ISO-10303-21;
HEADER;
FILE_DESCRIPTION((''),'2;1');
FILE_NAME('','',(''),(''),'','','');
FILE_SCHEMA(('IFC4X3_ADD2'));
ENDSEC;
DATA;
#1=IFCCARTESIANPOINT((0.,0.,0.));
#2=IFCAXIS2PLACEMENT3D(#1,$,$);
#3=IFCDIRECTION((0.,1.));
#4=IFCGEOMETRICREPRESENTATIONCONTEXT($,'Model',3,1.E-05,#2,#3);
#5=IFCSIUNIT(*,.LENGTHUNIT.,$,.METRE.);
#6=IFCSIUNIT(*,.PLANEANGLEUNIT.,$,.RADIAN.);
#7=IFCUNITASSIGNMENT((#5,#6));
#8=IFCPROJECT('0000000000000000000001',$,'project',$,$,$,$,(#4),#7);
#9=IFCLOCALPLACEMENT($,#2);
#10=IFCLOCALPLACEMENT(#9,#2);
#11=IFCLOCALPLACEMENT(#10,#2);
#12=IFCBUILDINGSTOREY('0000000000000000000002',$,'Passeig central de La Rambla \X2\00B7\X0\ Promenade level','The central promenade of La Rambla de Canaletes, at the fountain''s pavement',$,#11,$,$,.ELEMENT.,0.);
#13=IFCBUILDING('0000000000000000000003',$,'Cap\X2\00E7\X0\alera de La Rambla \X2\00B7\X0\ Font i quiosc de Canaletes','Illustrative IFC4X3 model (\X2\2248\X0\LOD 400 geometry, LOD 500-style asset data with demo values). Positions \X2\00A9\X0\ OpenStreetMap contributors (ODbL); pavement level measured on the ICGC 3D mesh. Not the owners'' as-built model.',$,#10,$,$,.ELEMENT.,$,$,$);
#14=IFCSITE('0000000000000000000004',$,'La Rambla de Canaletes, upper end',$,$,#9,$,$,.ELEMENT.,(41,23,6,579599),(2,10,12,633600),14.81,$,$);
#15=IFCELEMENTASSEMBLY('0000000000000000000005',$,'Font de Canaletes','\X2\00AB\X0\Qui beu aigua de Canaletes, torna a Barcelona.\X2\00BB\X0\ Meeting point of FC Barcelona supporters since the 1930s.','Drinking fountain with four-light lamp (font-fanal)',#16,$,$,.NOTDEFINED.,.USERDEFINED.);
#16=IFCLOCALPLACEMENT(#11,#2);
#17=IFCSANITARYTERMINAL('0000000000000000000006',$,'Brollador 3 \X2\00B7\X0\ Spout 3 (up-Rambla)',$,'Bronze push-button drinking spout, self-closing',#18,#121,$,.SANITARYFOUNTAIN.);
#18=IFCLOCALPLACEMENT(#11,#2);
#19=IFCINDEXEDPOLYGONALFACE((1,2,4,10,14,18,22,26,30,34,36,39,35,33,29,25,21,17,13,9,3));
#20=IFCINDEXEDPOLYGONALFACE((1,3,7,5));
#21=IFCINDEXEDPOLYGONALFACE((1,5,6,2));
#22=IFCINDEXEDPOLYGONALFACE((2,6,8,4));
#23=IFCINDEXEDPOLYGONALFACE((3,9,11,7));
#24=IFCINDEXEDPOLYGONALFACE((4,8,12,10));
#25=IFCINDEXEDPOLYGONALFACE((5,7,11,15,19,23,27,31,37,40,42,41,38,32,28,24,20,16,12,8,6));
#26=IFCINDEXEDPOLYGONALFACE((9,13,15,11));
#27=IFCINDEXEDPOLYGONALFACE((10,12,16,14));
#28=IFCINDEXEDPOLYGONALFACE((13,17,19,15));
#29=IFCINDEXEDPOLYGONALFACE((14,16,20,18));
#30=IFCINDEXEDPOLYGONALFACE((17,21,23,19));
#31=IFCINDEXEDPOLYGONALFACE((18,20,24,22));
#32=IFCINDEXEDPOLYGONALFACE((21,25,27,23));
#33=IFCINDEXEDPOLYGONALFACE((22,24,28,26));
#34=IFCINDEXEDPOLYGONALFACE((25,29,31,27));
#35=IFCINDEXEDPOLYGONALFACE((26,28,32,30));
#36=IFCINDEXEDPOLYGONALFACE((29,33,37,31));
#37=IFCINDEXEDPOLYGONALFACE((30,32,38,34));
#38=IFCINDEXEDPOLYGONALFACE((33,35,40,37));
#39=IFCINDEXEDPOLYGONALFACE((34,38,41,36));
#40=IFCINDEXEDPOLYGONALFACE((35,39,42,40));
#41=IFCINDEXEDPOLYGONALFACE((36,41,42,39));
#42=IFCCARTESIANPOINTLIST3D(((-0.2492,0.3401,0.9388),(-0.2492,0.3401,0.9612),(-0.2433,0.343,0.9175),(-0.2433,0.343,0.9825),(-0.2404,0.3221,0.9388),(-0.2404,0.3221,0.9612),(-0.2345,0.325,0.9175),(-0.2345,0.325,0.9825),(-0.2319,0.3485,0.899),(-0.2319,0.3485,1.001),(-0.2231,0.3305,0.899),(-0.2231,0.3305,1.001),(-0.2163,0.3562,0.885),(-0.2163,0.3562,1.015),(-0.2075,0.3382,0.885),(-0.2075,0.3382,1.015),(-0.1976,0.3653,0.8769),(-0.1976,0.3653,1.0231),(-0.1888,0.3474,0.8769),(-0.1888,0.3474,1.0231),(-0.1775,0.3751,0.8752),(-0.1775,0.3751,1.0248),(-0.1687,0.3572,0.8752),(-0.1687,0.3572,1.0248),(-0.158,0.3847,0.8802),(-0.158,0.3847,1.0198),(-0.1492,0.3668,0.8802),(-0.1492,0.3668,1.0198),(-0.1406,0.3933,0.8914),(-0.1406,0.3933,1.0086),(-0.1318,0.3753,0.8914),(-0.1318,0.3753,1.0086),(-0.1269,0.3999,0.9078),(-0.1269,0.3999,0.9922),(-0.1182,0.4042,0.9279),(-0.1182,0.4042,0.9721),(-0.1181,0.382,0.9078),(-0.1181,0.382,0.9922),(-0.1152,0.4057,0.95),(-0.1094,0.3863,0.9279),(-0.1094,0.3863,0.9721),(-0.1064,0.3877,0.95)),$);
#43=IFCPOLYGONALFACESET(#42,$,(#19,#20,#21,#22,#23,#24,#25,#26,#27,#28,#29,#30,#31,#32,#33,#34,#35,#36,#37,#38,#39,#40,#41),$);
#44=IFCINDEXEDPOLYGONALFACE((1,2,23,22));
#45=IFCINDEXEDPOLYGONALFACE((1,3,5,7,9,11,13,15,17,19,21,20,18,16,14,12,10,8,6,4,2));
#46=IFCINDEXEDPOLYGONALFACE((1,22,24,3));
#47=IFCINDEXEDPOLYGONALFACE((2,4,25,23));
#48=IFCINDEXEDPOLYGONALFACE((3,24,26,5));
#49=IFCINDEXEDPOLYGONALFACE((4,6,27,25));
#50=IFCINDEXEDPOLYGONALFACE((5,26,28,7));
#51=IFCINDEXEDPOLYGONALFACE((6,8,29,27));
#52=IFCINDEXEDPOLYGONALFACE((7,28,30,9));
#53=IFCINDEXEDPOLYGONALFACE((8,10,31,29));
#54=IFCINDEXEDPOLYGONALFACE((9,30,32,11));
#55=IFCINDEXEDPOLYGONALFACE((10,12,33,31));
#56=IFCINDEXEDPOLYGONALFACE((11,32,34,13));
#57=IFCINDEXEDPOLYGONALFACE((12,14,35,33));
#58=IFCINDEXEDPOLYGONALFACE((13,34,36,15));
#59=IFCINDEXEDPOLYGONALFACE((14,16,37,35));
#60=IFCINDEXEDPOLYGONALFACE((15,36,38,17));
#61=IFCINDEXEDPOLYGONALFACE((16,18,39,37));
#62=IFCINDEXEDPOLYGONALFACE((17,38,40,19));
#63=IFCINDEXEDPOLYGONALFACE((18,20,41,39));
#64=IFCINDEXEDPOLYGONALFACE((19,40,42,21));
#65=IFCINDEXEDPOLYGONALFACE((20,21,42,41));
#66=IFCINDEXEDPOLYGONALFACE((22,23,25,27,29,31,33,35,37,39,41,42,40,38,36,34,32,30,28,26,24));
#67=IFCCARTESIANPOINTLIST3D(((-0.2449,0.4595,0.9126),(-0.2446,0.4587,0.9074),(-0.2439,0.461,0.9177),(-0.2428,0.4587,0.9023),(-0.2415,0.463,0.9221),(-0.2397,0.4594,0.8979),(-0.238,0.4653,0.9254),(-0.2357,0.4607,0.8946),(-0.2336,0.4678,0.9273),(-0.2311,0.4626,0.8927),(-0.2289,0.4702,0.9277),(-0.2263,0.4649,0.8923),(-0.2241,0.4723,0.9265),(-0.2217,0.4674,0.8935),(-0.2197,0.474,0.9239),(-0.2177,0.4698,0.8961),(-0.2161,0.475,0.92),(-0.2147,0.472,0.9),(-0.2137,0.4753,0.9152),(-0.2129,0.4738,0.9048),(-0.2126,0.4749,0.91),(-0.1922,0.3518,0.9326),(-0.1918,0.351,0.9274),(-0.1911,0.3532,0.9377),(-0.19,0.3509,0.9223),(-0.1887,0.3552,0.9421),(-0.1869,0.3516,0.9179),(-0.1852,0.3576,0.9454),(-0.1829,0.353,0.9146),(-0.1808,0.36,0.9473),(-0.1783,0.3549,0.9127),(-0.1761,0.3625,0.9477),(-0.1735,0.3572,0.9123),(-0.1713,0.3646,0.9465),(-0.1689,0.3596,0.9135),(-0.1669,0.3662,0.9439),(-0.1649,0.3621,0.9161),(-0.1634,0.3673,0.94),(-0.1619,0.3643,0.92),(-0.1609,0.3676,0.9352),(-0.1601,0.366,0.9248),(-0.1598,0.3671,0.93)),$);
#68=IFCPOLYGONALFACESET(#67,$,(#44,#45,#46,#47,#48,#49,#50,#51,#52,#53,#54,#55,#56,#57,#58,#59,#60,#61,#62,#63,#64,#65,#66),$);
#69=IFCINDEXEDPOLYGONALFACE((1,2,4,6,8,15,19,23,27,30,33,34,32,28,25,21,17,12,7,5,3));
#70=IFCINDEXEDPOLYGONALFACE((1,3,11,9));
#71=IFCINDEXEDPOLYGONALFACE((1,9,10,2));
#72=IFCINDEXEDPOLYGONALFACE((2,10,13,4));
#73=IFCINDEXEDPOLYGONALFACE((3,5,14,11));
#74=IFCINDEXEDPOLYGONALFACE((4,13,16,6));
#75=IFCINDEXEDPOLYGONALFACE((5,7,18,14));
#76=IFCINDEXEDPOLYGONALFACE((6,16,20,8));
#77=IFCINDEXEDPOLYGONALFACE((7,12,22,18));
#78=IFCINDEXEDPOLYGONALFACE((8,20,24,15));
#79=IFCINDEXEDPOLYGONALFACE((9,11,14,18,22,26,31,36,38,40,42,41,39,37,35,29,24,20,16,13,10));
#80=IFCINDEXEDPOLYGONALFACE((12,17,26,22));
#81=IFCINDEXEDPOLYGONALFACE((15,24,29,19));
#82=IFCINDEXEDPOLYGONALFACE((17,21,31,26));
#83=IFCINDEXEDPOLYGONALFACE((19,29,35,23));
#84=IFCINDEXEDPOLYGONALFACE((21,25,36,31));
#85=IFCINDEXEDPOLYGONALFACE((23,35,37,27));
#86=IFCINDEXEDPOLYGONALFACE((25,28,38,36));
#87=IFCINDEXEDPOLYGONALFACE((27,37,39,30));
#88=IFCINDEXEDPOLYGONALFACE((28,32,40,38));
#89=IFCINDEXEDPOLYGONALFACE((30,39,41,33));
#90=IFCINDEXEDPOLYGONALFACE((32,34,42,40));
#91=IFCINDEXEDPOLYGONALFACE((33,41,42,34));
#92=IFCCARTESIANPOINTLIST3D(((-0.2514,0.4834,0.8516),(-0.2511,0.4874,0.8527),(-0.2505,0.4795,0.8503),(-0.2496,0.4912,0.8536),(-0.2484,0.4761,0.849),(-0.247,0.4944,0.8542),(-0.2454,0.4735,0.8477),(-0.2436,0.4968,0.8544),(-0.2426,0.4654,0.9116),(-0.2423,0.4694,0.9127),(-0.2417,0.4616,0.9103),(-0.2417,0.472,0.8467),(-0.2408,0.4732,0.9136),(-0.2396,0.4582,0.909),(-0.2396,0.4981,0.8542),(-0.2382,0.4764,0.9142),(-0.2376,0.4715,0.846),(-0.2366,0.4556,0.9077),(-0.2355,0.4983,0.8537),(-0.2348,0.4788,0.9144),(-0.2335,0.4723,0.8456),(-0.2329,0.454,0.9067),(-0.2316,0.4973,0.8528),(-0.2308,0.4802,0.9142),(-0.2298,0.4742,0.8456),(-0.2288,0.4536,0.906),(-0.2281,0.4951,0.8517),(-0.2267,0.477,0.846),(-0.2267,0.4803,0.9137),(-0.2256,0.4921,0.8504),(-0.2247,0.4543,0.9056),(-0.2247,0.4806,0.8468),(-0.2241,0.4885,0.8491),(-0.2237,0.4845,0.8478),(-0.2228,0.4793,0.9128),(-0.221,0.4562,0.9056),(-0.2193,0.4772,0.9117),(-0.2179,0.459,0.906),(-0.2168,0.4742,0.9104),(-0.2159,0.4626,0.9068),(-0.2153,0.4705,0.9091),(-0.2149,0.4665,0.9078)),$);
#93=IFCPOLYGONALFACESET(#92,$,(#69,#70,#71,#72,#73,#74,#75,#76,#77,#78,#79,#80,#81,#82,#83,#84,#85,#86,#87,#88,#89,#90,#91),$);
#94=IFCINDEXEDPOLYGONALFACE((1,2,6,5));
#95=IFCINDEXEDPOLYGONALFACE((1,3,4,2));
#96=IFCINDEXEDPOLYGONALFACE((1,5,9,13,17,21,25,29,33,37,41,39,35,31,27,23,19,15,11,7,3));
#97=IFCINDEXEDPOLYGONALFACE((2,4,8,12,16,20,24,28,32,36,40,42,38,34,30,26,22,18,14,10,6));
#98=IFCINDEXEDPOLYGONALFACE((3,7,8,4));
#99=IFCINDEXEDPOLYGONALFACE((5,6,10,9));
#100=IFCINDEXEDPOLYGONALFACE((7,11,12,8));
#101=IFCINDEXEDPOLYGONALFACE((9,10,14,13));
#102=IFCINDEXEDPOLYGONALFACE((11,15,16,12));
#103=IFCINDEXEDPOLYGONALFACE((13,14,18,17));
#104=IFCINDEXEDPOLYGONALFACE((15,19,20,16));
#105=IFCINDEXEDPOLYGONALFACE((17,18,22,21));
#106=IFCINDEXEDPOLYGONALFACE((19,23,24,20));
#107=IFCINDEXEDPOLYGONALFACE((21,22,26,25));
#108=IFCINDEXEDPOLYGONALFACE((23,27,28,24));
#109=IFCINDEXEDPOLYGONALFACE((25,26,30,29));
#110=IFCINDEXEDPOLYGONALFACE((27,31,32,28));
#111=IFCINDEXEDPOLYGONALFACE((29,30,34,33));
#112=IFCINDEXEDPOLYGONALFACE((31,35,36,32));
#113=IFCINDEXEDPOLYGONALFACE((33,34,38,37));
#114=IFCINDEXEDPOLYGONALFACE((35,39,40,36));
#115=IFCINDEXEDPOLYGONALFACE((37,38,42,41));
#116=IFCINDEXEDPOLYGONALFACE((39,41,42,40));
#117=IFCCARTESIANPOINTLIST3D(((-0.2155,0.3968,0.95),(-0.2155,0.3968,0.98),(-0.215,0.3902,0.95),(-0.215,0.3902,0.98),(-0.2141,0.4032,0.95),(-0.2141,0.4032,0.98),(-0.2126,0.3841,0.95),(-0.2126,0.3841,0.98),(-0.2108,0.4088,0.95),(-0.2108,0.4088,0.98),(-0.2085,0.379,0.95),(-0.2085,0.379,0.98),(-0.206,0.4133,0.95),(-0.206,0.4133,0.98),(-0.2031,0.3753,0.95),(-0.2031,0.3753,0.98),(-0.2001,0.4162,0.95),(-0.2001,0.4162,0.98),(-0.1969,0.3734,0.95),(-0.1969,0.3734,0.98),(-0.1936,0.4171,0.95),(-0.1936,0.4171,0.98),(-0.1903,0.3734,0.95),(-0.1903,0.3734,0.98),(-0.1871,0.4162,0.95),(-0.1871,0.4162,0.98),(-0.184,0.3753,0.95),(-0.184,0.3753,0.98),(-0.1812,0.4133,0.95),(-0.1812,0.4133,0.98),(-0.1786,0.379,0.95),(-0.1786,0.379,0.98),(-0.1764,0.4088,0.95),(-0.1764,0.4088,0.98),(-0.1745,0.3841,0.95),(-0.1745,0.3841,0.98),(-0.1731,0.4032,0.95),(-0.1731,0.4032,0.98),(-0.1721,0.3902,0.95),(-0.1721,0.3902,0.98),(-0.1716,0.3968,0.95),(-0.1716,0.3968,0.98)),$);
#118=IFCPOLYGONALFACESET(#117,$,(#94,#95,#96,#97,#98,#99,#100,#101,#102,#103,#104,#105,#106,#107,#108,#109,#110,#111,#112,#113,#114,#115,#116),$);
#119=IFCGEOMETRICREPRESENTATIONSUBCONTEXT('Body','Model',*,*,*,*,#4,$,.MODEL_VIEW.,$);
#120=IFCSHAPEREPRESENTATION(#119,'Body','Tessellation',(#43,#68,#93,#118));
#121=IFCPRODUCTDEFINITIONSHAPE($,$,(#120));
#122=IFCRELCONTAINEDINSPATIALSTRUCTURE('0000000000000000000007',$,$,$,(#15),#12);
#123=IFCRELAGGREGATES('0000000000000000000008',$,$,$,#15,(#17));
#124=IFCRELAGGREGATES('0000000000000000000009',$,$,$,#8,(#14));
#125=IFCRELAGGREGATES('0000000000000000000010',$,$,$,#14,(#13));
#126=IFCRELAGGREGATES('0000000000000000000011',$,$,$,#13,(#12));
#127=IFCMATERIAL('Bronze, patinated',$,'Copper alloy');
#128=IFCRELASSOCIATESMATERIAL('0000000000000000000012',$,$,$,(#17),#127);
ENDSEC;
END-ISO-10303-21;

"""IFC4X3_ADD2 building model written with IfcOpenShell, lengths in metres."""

from ifc_helpers import new_model, si_unit, direction, frame, origin, origin_2d_with_axis, place, context, subcontext, project, spatial, circle, extrude, material, element, aggregate, save


model = new_model("IFC4X3_ADD2")

# Units and contexts
model_context = context("Model", 3, precision=1e-05, world=origin(), true_north=direction((0.0, 1.0)))
body_context = subcontext(model_context, "Body", "Model", "MODEL_VIEW")
ifc_project = project(units=[si_unit("LENGTHUNIT", "METRE"), si_unit("PLANEANGLEUNIT", "RADIAN")], contexts=[model_context])

# Site, building, storey
site_placement = place(None, origin())
site = spatial("IfcSite", under=ifc_project, at=site_placement, Name="La Rambla de Canaletes, upper end", CompositionType="ELEMENT", RefLatitude=(41, 23, 6, 579599), RefLongitude=(2, 10, 12, 633600), RefElevation=14.81)
building_placement = place(site_placement, origin())
building = spatial("IfcBuilding", under=site, at=building_placement, Name="Capçalera de La Rambla · Font i quiosc de Canaletes", Description="Illustrative IFC4X3 model (≈LOD 400 geometry, LOD 500-style asset data with demo values). Positions © OpenStreetMap contributors (ODbL); pavement level measured on the ICGC 3D mesh. Not the owners' as-built model.", CompositionType="ELEMENT")
storey_placement = place(building_placement, origin())
storey = spatial("IfcBuildingStorey", under=building, at=storey_placement, Name="Passeig central de La Rambla · Promenade level", Description="The central promenade of La Rambla de Canaletes, at the fountain's pavement", CompositionType="ELEMENT", Elevation=0.0)

# Element assembly, sanitary terminal
assembly_1_placement = place(building_placement, origin())
assembly_1 = element("IfcElementAssembly", 1, at=assembly_1_placement, inside=storey, Name="Font de Canaletes", Description="«Qui beu aigua de Canaletes, torna a Barcelona.» Meeting point of FC Barcelona supporters since the 1930s.", ObjectType="Drinking fountain with four-light lamp (font-fanal)", AssemblyPlace="NOTDEFINED", PredefinedType="USERDEFINED")
ifc_material_1 = material(Name="Bronze, patinated", Category="Copper alloy")
sanitary_terminal_1_placement = place(building_placement, origin())
sanitary_terminal_1 = element("IfcSanitaryTerminal", 2, at=sanitary_terminal_1_placement, material=ifc_material_1, Name="Brollador 3 · Spout 3 (up-Rambla)", ObjectType="Bronze push-button drinking spout, self-closing", PredefinedType="SANITARYFOUNTAIN", context=body_context, shape_type="SweptSolid", body=[
    extrude(circle(Radius=0.075, at=origin_2d_with_axis()), frame((-0.1738, 0.3547, 0.95), z_axis=(-0.439939, 0.898028, 0.0), x_axis=(0.898028, 0.439939, 0.0)), (0.0, 0.0, 1.0), 0.02),
    extrude(circle(Radius=0.018, at=origin_2d_with_axis()), frame((-0.176, 0.3592, 0.93), z_axis=(-0.433953, 0.885809, -0.164399), x_axis=(0.898028, 0.439939, 0.0)), (0.0, 0.0, 1.0), 0.1217),
    extrude(circle(Radius=0.014, at=origin_2d_with_axis()), frame((-0.2288, 0.467, 0.91), z_axis=(-0.139121, 0.283981, -0.948683), x_axis=(0.0, -0.957999, -0.28677)), (0.0, 0.0, 1.0), 0.0632),
    extrude(circle(Radius=0.022, at=origin_2d_with_axis()), frame((-0.1936, 0.3951, 0.95), z_axis=(0.0, 0.0, 1.0), x_axis=(0.0, 1.0, 0.0)), (0.0, 0.0, 1.0), 0.03),
])
aggregate(assembly_1, [sanitary_terminal_1])

save(model, "model.ifc")
